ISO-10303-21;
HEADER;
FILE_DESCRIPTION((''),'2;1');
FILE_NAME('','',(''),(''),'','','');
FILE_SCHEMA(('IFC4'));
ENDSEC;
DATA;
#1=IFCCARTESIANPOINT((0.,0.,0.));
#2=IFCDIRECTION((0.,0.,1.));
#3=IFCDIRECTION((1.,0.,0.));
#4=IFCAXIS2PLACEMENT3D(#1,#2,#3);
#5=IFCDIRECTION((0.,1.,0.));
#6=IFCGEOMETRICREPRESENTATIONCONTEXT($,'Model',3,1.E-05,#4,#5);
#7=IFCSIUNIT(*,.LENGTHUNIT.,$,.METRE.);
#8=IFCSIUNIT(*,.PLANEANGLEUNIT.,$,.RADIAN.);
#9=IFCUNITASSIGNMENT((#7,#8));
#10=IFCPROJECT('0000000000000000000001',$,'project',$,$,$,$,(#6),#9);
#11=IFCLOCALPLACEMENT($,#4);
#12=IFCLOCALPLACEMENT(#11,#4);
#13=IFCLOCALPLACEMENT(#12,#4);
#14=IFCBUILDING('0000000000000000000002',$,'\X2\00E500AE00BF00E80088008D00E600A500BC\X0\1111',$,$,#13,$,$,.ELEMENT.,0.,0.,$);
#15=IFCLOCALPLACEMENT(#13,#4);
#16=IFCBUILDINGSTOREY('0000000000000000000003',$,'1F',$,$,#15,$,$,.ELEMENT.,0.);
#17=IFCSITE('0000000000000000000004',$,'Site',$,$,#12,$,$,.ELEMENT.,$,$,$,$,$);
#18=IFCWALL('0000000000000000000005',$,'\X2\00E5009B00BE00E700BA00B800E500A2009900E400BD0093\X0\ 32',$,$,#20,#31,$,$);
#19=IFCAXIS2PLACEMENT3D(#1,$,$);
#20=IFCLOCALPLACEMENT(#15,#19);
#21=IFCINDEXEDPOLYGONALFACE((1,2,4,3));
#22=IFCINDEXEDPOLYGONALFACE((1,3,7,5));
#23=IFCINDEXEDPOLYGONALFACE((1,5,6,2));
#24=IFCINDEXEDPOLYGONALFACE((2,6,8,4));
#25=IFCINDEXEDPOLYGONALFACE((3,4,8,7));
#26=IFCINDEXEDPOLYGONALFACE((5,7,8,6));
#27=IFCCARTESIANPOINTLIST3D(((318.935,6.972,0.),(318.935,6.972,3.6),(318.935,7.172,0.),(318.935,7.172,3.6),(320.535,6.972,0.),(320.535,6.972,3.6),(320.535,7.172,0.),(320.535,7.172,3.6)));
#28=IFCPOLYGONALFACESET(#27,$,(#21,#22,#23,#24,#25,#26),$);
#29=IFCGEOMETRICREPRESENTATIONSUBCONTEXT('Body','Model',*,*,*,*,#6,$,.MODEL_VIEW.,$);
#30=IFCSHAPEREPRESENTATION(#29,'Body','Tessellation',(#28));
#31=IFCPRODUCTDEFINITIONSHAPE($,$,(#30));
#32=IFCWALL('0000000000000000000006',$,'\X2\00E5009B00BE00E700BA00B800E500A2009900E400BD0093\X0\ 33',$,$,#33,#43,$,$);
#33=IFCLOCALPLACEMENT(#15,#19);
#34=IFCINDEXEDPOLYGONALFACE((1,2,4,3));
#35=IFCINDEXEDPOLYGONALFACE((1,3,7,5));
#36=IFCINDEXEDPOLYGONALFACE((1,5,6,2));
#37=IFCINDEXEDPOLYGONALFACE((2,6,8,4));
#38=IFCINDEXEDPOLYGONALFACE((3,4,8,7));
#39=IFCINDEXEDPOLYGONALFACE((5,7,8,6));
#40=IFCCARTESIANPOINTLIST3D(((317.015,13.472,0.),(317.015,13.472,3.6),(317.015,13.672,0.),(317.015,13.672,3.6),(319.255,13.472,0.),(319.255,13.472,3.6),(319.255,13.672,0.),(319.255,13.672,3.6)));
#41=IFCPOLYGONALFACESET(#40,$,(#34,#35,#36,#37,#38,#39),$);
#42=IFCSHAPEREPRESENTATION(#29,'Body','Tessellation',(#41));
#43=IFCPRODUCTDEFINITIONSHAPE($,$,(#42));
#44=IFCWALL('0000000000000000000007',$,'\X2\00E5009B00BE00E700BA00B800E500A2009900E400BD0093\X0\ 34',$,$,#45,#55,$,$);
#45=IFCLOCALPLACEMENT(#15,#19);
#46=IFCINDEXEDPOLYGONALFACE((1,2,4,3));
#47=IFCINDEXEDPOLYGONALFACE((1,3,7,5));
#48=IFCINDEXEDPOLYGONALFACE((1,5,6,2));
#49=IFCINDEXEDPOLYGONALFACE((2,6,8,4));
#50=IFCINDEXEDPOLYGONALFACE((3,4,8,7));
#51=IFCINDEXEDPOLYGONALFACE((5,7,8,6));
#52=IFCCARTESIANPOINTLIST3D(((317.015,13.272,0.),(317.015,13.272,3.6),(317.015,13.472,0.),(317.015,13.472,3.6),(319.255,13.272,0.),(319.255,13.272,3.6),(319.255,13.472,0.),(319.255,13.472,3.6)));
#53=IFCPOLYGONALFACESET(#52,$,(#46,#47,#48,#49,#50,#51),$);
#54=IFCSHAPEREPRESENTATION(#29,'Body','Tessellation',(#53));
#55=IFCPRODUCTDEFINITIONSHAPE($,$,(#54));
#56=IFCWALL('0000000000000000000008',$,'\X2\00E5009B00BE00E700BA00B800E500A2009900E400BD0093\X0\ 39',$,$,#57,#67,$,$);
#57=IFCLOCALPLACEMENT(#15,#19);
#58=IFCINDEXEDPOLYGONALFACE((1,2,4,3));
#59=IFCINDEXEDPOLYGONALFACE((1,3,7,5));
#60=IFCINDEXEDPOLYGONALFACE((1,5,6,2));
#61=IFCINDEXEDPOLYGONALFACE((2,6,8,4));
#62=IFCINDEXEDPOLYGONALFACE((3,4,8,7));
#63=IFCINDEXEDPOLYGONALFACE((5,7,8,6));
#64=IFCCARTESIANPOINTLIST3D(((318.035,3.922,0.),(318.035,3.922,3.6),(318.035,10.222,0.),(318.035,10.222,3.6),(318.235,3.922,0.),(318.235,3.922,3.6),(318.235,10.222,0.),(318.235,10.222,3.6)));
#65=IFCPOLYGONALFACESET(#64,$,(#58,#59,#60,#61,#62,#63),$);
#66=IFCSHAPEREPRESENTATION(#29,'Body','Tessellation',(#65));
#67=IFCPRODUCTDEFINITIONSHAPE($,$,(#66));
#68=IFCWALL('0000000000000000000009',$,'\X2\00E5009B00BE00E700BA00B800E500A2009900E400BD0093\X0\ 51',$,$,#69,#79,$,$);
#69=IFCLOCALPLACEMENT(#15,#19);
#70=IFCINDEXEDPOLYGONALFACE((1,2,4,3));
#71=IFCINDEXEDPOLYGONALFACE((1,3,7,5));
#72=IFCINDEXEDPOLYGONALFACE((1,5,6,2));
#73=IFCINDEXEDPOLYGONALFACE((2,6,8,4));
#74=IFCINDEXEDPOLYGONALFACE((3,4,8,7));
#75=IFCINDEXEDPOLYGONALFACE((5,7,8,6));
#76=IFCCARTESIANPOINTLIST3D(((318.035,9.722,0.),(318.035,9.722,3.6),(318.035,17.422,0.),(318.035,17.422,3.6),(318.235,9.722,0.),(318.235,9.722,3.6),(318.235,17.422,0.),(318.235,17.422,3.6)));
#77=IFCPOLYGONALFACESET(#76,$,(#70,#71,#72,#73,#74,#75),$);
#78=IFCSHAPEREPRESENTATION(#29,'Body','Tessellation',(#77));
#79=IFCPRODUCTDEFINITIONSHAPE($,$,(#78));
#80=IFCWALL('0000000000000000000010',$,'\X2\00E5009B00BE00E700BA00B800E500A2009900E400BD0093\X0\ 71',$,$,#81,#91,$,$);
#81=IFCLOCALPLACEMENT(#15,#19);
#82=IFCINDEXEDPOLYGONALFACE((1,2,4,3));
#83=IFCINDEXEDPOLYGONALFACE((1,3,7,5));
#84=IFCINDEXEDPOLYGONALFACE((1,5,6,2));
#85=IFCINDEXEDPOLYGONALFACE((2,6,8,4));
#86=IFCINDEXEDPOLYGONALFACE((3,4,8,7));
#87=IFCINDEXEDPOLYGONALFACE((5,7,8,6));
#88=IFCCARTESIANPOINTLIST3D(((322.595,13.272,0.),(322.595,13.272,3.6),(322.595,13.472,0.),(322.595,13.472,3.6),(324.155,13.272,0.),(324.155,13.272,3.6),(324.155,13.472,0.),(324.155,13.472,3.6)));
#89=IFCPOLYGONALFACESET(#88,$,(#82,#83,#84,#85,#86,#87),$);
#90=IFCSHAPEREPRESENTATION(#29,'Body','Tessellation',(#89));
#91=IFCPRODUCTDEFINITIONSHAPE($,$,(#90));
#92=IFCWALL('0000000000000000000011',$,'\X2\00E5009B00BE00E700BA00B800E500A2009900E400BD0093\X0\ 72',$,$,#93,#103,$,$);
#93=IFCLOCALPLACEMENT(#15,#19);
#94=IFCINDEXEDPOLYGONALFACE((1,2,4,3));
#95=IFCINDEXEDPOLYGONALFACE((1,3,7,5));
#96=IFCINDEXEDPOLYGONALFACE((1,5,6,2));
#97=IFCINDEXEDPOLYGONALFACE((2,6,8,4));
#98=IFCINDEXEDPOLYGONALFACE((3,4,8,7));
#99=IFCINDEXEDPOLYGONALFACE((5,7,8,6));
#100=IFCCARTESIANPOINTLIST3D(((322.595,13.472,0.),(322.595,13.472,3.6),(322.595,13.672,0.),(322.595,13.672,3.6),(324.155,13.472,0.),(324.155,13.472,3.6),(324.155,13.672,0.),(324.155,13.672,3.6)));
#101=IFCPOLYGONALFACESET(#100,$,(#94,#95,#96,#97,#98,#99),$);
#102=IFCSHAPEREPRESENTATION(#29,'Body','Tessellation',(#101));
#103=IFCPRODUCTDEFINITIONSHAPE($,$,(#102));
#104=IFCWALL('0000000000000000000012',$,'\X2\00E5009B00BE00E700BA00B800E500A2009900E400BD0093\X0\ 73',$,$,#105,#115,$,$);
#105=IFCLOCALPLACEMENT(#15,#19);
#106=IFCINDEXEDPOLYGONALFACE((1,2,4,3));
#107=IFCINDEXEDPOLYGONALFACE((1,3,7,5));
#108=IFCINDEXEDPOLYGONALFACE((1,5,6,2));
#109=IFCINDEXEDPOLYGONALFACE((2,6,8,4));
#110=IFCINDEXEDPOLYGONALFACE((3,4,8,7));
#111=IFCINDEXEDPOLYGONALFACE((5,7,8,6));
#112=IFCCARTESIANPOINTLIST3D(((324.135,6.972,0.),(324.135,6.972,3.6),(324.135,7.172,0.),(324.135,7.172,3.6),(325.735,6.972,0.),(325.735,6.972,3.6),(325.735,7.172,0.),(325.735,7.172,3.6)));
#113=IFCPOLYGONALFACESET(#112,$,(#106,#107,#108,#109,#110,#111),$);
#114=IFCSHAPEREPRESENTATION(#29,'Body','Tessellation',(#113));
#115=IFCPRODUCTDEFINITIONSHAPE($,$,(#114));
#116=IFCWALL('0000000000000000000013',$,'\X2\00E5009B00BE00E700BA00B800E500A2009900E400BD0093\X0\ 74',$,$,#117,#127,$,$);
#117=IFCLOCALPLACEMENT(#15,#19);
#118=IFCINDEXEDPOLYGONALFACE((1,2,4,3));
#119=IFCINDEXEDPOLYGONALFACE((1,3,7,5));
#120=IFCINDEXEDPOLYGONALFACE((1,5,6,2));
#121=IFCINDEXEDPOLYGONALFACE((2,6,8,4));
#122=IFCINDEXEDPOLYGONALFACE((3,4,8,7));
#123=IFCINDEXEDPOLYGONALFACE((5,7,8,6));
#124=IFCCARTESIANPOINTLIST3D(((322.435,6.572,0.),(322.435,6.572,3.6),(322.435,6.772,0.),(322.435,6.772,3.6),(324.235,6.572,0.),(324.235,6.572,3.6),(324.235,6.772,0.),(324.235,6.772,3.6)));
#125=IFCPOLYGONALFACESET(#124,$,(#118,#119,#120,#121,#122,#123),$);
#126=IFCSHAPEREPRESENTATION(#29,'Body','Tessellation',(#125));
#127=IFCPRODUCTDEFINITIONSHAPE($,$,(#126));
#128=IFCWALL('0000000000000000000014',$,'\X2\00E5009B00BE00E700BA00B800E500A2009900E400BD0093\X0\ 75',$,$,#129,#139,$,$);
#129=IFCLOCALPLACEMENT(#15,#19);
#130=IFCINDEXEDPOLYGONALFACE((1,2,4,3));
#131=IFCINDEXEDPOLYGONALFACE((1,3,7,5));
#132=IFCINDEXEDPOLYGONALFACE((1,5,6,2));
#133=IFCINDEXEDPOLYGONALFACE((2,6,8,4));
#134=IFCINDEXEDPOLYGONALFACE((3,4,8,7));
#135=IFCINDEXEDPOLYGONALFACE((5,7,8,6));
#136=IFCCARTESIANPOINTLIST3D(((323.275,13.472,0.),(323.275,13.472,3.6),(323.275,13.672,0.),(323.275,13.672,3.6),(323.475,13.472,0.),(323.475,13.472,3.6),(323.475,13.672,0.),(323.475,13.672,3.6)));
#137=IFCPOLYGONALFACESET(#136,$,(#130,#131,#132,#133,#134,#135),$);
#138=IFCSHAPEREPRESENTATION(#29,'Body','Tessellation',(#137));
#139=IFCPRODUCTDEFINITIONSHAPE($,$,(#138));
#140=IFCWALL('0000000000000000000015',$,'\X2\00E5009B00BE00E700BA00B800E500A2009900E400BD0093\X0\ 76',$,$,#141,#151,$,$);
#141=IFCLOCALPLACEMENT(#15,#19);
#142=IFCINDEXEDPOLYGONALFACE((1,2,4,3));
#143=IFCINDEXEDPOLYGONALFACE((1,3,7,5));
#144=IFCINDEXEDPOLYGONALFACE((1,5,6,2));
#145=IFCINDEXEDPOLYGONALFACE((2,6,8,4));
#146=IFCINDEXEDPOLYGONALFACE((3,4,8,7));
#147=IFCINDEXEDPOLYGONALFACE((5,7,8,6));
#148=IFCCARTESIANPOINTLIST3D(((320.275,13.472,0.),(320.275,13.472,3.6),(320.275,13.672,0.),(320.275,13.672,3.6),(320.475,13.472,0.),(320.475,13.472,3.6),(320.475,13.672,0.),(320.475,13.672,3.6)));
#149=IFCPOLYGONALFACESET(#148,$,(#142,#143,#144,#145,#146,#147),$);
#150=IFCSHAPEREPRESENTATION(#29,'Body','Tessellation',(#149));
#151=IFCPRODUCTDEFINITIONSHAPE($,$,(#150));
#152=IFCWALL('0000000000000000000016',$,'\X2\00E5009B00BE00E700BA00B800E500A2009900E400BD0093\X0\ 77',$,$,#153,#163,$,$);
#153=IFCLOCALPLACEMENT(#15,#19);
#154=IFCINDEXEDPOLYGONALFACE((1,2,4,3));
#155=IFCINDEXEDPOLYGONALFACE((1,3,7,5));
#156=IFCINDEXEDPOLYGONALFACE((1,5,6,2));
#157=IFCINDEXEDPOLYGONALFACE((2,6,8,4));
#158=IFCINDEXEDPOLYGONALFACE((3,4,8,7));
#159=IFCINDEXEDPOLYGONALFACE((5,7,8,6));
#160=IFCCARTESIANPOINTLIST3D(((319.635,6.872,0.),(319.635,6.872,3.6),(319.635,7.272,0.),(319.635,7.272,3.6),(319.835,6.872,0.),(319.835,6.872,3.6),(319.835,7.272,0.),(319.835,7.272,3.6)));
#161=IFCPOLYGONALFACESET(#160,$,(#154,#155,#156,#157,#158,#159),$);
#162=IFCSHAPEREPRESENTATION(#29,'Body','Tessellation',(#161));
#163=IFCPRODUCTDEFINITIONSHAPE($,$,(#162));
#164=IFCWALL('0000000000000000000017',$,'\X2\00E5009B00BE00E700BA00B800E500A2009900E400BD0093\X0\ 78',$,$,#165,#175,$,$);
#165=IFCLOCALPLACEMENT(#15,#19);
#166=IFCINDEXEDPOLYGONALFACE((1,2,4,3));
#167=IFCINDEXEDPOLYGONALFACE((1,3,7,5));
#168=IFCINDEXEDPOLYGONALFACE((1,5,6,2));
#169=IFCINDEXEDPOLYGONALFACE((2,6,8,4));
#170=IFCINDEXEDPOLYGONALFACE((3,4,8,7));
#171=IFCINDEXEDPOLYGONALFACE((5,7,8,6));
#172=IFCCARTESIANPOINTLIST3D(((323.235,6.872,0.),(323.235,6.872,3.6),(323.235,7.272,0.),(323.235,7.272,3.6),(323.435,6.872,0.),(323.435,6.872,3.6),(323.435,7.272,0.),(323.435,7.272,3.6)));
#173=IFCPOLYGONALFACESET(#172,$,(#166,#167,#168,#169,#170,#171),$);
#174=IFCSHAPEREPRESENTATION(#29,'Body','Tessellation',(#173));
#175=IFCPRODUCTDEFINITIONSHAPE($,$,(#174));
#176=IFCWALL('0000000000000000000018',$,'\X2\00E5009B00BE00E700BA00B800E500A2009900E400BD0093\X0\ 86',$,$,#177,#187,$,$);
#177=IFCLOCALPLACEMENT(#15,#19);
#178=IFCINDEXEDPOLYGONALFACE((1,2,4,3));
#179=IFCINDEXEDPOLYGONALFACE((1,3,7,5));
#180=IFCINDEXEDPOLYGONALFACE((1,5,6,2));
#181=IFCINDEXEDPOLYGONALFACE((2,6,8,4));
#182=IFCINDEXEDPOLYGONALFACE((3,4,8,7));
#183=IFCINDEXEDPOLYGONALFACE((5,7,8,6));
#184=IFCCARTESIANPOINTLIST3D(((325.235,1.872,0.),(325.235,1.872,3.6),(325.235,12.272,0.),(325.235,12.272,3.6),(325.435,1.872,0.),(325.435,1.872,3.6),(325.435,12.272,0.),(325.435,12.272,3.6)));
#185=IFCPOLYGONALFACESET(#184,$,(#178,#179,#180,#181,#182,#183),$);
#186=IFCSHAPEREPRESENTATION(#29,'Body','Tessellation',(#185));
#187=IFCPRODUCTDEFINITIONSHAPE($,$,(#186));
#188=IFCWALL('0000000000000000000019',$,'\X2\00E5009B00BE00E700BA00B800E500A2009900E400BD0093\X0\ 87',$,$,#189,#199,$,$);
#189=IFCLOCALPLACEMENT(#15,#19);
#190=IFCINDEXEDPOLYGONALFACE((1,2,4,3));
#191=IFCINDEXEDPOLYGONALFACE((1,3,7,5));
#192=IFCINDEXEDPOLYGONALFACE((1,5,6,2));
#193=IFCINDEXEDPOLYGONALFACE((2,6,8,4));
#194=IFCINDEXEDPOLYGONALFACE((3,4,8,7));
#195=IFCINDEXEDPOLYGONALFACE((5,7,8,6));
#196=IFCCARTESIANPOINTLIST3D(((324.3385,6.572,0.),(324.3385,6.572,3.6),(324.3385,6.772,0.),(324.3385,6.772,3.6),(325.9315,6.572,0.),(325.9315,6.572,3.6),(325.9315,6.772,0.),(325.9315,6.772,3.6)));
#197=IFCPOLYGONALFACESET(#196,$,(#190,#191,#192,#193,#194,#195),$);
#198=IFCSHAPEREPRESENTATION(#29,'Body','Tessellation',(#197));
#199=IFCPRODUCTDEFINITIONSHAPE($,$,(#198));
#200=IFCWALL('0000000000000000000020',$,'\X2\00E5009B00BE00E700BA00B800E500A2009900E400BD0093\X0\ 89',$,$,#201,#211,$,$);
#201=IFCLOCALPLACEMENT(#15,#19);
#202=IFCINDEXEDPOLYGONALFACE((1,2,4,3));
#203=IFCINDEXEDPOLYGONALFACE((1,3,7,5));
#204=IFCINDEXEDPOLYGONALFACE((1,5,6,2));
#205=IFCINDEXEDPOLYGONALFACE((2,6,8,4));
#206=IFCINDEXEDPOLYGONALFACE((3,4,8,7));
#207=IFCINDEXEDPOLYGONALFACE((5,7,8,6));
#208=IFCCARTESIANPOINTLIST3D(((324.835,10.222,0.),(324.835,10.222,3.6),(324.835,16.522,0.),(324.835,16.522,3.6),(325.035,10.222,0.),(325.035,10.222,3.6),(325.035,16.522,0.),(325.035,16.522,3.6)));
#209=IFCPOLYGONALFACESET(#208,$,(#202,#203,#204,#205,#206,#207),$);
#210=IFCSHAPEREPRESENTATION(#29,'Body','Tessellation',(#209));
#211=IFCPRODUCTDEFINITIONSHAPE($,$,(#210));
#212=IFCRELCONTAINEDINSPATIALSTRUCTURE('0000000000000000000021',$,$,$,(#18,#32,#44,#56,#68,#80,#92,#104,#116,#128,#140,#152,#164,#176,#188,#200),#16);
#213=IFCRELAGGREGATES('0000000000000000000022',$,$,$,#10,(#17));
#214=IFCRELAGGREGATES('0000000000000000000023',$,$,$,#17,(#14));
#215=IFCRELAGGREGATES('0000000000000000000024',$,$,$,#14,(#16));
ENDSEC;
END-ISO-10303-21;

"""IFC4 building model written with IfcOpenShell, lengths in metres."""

from ifc_helpers import new_model, si_unit, direction, frame, frame_2d, origin_with_axes, place, context, subcontext, project, spatial, rectangle, extrude, element, save


model = new_model("IFC4")

# Units and contexts
model_context = context("Model", 3, precision=1e-05, world=origin_with_axes(), true_north=direction((0.0, 1.0, 0.0)))
body_context = subcontext(model_context, "Body", "Model", "MODEL_VIEW")
ifc_project = project(units=[si_unit("LENGTHUNIT", "METRE"), si_unit("PLANEANGLEUNIT", "RADIAN")], contexts=[model_context])

# Site, building, storey
placement = place(None, origin_with_axes())
site_placement = place(placement, origin_with_axes())
site = spatial("IfcSite", under=ifc_project, at=site_placement, Name="Site", CompositionType="ELEMENT")
building_placement = place(site_placement, origin_with_axes())
building = spatial("IfcBuilding", under=site, at=building_placement, Name="å®¿è\u0088\u008dæ¥¼1111", CompositionType="ELEMENT", ElevationOfRefHeight=0.0, ElevationOfTerrain=0.0)
storey_placement = place(building_placement, origin_with_axes())
storey = spatial("IfcBuildingStorey", under=building, at=storey_placement, Name="1F", CompositionType="ELEMENT", Elevation=0.0)

# Walls
wall_1_placement = place(storey_placement, frame((319.735, 7.072, 0.0), z_axis=(0.0, 0.0, 1.0), x_axis=(-1.0, 0.0, 0.0)))
element("IfcWall", 1, at=wall_1_placement, inside=storey, Name="å\u009b¾çº¸å¢\u0099ä½\u0093 32", context=body_context, shape_type="SweptSolid", body=[
    extrude(rectangle(XDim=1.6, YDim=0.2, at=frame_2d((0.0, 0.0), x_axis=(1.0, 0.0, 0.0))), frame((0.0, 0.0, 0.0), z_axis=(0.0, 0.0, 1.0)), (0.0, 0.0, 1.0), 3.6),
])
for number, where, z_axis, x_axis, name in (
    (2, (318.135, 13.572, 0.0), (0.0, 0.0, 1.0), (1.0, 0.0, 0.0), "å\u009b¾çº¸å¢\u0099ä½\u0093 33"),
    (3, (318.135, 13.372, 0.0), (0.0, 0.0, 1.0), (1.0, 0.0, 0.0), "å\u009b¾çº¸å¢\u0099ä½\u0093 34"),
):
    element("IfcWall", number, at=place(storey_placement, frame(where, z_axis=z_axis, x_axis=x_axis)), inside=storey, Name=name, context=body_context, shape_type="SweptSolid", body=[
        extrude(rectangle(XDim=2.24, YDim=0.2, at=frame_2d((0.0, 0.0), x_axis=(1.0, 0.0, 0.0))), frame((0.0, 0.0, 0.0), z_axis=(0.0, 0.0, 1.0)), (0.0, 0.0, 1.0), 3.6),
    ])
wall_2_placement = place(storey_placement, frame((318.135, 7.072, 0.0), z_axis=(0.0, 0.0, 1.0), x_axis=(0.0, 1.0, 0.0)))
element("IfcWall", 4, at=wall_2_placement, inside=storey, Name="å\u009b¾çº¸å¢\u0099ä½\u0093 39", context=body_context, shape_type="SweptSolid", body=[
    extrude(rectangle(XDim=6.3, YDim=0.2, at=frame_2d((0.0, 0.0), x_axis=(1.0, 0.0, 0.0))), frame((0.0, 0.0, 0.0), z_axis=(0.0, 0.0, 1.0)), (0.0, 0.0, 1.0), 3.6),
])
wall_3_placement = place(storey_placement, frame((318.135, 13.572, 0.0), z_axis=(0.0, 0.0, 1.0), x_axis=(0.0, 1.0, 0.0)))
element("IfcWall", 5, at=wall_3_placement, inside=storey, Name="å\u009b¾çº¸å¢\u0099ä½\u0093 51", context=body_context, shape_type="SweptSolid", body=[
    extrude(rectangle(XDim=7.7, YDim=0.2, at=frame_2d((0.0, 0.0), x_axis=(1.0, 0.0, 0.0))), frame((0.0, 0.0, 0.0), z_axis=(0.0, 0.0, 1.0)), (0.0, 0.0, 1.0), 3.6),
])
for number, where, z_axis, x_axis, name in (
    (6, (323.375, 13.372, 0.0), (0.0, 0.0, 1.0), (1.0, 0.0, 0.0), "å\u009b¾çº¸å¢\u0099ä½\u0093 71"),
    (7, (323.375, 13.572, 0.0), (0.0, 0.0, 1.0), (1.0, 0.0, 0.0), "å\u009b¾çº¸å¢\u0099ä½\u0093 72"),
):
    element("IfcWall", number, at=place(storey_placement, frame(where, z_axis=z_axis, x_axis=x_axis)), inside=storey, Name=name, context=body_context, shape_type="SweptSolid", body=[
        extrude(rectangle(XDim=1.56, YDim=0.2, at=frame_2d((0.0, 0.0), x_axis=(1.0, 0.0, 0.0))), frame((0.0, 0.0, 0.0), z_axis=(0.0, 0.0, 1.0)), (0.0, 0.0, 1.0), 3.6),
    ])
wall_4_placement = place(storey_placement, frame((324.935, 7.072, 0.0), z_axis=(0.0, 0.0, 1.0), x_axis=(-1.0, 0.0, 0.0)))
element("IfcWall", 8, at=wall_4_placement, inside=storey, Name="å\u009b¾çº¸å¢\u0099ä½\u0093 73", context=body_context, shape_type="SweptSolid", body=[
    extrude(rectangle(XDim=1.6, YDim=0.2, at=frame_2d((0.0, 0.0), x_axis=(1.0, 0.0, 0.0))), frame((0.0, 0.0, 0.0), z_axis=(0.0, 0.0, 1.0)), (0.0, 0.0, 1.0), 3.6),
])
wall_5_placement = place(storey_placement, frame((323.335, 6.672, 0.0), z_axis=(0.0, 0.0, 1.0), x_axis=(1.0, 0.0, 0.0)))
element("IfcWall", 9, at=wall_5_placement, inside=storey, Name="å\u009b¾çº¸å¢\u0099ä½\u0093 74", context=body_context, shape_type="SweptSolid", body=[
    extrude(rectangle(XDim=1.8, YDim=0.2, at=frame_2d((0.0, 0.0), x_axis=(1.0, 0.0, 0.0))), frame((0.0, 0.0, 0.0), z_axis=(0.0, 0.0, 1.0)), (0.0, 0.0, 1.0), 3.6),
])
for number, where, z_axis, x_axis, name in (
    (10, (323.375, 13.572, 0.0), (0.0, 0.0, 1.0), (0.0, -1.0, 0.0), "å\u009b¾çº¸å¢\u0099ä½\u0093 75"),
    (11, (320.375, 13.572, 0.0), (0.0, 0.0, 1.0), (0.0, -1.0, 0.0), "å\u009b¾çº¸å¢\u0099ä½\u0093 76"),
):
    element("IfcWall", number, at=place(storey_placement, frame(where, z_axis=z_axis, x_axis=x_axis)), inside=storey, Name=name, context=body_context, shape_type="SweptSolid", body=[
        extrude(rectangle(XDim=0.2, YDim=0.2, at=frame_2d((0.0, 0.0), x_axis=(1.0, 0.0, 0.0))), frame((0.0, 0.0, 0.0), z_axis=(0.0, 0.0, 1.0)), (0.0, 0.0, 1.0), 3.6),
    ])
for number, where, z_axis, x_axis, name in (
    (12, (319.735, 7.072, 0.0), (0.0, 0.0, 1.0), (0.0, -1.0, 0.0), "å\u009b¾çº¸å¢\u0099ä½\u0093 77"),
    (13, (323.335, 7.072, 0.0), (0.0, 0.0, 1.0), (0.0, -1.0, 0.0), "å\u009b¾çº¸å¢\u0099ä½\u0093 78"),
):
    element("IfcWall", number, at=place(storey_placement, frame(where, z_axis=z_axis, x_axis=x_axis)), inside=storey, Name=name, context=body_context, shape_type="SweptSolid", body=[
        extrude(rectangle(XDim=0.4, YDim=0.2, at=frame_2d((0.0, 0.0), x_axis=(1.0, 0.0, 0.0))), frame((0.0, 0.0, 0.0), z_axis=(0.0, 0.0, 1.0)), (0.0, 0.0, 1.0), 3.6),
    ])
wall_6_placement = place(storey_placement, frame((325.335, 7.072, 0.0), z_axis=(0.0, 0.0, 1.0), x_axis=(0.0, 1.0, 0.0)))
element("IfcWall", 14, at=wall_6_placement, inside=storey, Name="å\u009b¾çº¸å¢\u0099ä½\u0093 86", context=body_context, shape_type="SweptSolid", body=[
    extrude(rectangle(XDim=10.4, YDim=0.2, at=frame_2d((0.0, 0.0), x_axis=(1.0, 0.0, 0.0))), frame((0.0, 0.0, 0.0), z_axis=(0.0, 0.0, 1.0)), (0.0, 0.0, 1.0), 3.6),
])
wall_7_placement = place(storey_placement, frame((325.135, 6.672, 0.0), z_axis=(0.0, 0.0, 1.0), x_axis=(1.0, 0.0, 0.0)))
element("IfcWall", 15, at=wall_7_placement, inside=storey, Name="å\u009b¾çº¸å¢\u0099ä½\u0093 87", context=body_context, shape_type="SweptSolid", body=[
    extrude(rectangle(XDim=1.593, YDim=0.2, at=frame_2d((0.0, 0.0), x_axis=(1.0, 0.0, 0.0))), frame((0.0, 0.0, 0.0), z_axis=(0.0, 0.0, 1.0)), (0.0, 0.0, 1.0), 3.6),
])
wall_8_placement = place(storey_placement, frame((324.935, 13.372, 0.0), z_axis=(0.0, 0.0, 1.0), x_axis=(0.0, -1.0, 0.0)))
element("IfcWall", 16, at=wall_8_placement, inside=storey, Name="å\u009b¾çº¸å¢\u0099ä½\u0093 89", context=body_context, shape_type="SweptSolid", body=[
    extrude(rectangle(XDim=6.3, YDim=0.2, at=frame_2d((0.0, 0.0), x_axis=(1.0, 0.0, 0.0))), frame((0.0, 0.0, 0.0), z_axis=(0.0, 0.0, 1.0)), (0.0, 0.0, 1.0), 3.6),
])

save(model, "model.ifc")
